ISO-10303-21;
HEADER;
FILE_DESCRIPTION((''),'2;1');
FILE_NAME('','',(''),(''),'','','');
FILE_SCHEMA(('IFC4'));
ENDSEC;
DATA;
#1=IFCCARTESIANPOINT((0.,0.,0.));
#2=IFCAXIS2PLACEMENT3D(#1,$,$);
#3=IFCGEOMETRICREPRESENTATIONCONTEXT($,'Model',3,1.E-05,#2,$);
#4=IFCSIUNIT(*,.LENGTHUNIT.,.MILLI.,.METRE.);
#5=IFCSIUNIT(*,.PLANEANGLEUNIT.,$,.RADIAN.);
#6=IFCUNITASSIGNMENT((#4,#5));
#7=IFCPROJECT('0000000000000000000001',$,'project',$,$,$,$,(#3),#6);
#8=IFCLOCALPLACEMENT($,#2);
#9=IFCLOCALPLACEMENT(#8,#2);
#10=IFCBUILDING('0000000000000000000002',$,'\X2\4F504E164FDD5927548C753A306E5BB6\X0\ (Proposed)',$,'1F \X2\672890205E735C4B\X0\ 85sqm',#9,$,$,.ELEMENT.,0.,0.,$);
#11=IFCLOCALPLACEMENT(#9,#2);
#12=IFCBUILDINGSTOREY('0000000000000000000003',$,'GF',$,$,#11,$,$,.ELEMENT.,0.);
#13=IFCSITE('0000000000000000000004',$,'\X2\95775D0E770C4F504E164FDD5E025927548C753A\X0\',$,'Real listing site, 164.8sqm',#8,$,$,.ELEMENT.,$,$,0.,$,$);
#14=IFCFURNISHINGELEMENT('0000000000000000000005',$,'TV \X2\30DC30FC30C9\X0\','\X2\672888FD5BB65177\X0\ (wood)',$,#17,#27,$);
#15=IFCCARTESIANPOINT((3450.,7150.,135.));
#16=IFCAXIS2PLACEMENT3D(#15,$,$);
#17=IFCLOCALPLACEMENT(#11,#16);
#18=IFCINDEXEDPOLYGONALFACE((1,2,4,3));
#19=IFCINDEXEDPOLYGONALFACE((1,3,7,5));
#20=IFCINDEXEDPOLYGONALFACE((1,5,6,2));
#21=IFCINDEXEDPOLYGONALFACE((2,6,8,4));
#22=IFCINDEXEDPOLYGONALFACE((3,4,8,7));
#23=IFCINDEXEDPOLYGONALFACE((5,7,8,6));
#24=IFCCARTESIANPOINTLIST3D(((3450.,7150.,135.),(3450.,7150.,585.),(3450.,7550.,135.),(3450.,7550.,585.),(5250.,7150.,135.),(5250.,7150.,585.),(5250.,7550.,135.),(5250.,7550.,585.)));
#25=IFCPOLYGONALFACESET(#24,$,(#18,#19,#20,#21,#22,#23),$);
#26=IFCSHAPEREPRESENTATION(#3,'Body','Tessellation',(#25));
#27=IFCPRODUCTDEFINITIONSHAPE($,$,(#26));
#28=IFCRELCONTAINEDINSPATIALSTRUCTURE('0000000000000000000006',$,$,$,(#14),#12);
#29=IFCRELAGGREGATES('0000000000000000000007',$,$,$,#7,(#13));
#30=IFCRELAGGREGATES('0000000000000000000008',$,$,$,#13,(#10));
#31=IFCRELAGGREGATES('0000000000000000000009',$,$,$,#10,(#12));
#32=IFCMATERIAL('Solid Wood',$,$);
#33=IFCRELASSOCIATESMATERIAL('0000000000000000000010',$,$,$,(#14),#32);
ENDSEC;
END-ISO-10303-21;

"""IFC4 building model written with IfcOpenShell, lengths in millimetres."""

from ifc_helpers import new_model, si_unit, frame, frame_2d, origin, place, context, project, spatial, rectangle, extrude, material, element, save


model = new_model("IFC4")

# Units and contexts
model_context = context("Model", 3, precision=1e-05, world=origin())
ifc_project = project(units=[si_unit("LENGTHUNIT", "METRE", prefix="MILLI"), si_unit("PLANEANGLEUNIT", "RADIAN")], contexts=[model_context])

# Site, building, storey
site_placement = place(None, origin())
site = spatial("IfcSite", under=ifc_project, at=site_placement, Name="長崎県佐世保市大和町", ObjectType="Real listing site, 164.8sqm", CompositionType="ELEMENT", RefElevation=0.0)
building_placement = place(site_placement, origin())
building = spatial("IfcBuilding", under=site, at=building_placement, Name="佐世保大和町の家 (Proposed)", ObjectType="1F 木造平屋 85sqm", CompositionType="ELEMENT", ElevationOfRefHeight=0.0, ElevationOfTerrain=0.0)
storey_placement = place(building_placement, origin())
storey = spatial("IfcBuildingStorey", under=building, at=storey_placement, Name="GF", CompositionType="ELEMENT", Elevation=0.0)

# Shared definitions
ifc_material_1 = material(Name="Solid Wood")

# Furnishing element
furnishing_1_placement = place(storey_placement, frame((3450.0, 7150.0, 135.0)))
element("IfcFurnishingElement", 1, at=furnishing_1_placement, inside=storey, material=ifc_material_1, Name="TV ボード", Description="木製家具 (wood)", context=model_context, shape_type="SweptSolid", body=[
    extrude(rectangle(XDim=1800.0, YDim=400.0, at=frame_2d((900.0, 200.0))), frame((3450.0, 7150.0, 135.0)), (0.0, 0.0, 1.0), 450.0),
])

save(model, "model.ifc")
